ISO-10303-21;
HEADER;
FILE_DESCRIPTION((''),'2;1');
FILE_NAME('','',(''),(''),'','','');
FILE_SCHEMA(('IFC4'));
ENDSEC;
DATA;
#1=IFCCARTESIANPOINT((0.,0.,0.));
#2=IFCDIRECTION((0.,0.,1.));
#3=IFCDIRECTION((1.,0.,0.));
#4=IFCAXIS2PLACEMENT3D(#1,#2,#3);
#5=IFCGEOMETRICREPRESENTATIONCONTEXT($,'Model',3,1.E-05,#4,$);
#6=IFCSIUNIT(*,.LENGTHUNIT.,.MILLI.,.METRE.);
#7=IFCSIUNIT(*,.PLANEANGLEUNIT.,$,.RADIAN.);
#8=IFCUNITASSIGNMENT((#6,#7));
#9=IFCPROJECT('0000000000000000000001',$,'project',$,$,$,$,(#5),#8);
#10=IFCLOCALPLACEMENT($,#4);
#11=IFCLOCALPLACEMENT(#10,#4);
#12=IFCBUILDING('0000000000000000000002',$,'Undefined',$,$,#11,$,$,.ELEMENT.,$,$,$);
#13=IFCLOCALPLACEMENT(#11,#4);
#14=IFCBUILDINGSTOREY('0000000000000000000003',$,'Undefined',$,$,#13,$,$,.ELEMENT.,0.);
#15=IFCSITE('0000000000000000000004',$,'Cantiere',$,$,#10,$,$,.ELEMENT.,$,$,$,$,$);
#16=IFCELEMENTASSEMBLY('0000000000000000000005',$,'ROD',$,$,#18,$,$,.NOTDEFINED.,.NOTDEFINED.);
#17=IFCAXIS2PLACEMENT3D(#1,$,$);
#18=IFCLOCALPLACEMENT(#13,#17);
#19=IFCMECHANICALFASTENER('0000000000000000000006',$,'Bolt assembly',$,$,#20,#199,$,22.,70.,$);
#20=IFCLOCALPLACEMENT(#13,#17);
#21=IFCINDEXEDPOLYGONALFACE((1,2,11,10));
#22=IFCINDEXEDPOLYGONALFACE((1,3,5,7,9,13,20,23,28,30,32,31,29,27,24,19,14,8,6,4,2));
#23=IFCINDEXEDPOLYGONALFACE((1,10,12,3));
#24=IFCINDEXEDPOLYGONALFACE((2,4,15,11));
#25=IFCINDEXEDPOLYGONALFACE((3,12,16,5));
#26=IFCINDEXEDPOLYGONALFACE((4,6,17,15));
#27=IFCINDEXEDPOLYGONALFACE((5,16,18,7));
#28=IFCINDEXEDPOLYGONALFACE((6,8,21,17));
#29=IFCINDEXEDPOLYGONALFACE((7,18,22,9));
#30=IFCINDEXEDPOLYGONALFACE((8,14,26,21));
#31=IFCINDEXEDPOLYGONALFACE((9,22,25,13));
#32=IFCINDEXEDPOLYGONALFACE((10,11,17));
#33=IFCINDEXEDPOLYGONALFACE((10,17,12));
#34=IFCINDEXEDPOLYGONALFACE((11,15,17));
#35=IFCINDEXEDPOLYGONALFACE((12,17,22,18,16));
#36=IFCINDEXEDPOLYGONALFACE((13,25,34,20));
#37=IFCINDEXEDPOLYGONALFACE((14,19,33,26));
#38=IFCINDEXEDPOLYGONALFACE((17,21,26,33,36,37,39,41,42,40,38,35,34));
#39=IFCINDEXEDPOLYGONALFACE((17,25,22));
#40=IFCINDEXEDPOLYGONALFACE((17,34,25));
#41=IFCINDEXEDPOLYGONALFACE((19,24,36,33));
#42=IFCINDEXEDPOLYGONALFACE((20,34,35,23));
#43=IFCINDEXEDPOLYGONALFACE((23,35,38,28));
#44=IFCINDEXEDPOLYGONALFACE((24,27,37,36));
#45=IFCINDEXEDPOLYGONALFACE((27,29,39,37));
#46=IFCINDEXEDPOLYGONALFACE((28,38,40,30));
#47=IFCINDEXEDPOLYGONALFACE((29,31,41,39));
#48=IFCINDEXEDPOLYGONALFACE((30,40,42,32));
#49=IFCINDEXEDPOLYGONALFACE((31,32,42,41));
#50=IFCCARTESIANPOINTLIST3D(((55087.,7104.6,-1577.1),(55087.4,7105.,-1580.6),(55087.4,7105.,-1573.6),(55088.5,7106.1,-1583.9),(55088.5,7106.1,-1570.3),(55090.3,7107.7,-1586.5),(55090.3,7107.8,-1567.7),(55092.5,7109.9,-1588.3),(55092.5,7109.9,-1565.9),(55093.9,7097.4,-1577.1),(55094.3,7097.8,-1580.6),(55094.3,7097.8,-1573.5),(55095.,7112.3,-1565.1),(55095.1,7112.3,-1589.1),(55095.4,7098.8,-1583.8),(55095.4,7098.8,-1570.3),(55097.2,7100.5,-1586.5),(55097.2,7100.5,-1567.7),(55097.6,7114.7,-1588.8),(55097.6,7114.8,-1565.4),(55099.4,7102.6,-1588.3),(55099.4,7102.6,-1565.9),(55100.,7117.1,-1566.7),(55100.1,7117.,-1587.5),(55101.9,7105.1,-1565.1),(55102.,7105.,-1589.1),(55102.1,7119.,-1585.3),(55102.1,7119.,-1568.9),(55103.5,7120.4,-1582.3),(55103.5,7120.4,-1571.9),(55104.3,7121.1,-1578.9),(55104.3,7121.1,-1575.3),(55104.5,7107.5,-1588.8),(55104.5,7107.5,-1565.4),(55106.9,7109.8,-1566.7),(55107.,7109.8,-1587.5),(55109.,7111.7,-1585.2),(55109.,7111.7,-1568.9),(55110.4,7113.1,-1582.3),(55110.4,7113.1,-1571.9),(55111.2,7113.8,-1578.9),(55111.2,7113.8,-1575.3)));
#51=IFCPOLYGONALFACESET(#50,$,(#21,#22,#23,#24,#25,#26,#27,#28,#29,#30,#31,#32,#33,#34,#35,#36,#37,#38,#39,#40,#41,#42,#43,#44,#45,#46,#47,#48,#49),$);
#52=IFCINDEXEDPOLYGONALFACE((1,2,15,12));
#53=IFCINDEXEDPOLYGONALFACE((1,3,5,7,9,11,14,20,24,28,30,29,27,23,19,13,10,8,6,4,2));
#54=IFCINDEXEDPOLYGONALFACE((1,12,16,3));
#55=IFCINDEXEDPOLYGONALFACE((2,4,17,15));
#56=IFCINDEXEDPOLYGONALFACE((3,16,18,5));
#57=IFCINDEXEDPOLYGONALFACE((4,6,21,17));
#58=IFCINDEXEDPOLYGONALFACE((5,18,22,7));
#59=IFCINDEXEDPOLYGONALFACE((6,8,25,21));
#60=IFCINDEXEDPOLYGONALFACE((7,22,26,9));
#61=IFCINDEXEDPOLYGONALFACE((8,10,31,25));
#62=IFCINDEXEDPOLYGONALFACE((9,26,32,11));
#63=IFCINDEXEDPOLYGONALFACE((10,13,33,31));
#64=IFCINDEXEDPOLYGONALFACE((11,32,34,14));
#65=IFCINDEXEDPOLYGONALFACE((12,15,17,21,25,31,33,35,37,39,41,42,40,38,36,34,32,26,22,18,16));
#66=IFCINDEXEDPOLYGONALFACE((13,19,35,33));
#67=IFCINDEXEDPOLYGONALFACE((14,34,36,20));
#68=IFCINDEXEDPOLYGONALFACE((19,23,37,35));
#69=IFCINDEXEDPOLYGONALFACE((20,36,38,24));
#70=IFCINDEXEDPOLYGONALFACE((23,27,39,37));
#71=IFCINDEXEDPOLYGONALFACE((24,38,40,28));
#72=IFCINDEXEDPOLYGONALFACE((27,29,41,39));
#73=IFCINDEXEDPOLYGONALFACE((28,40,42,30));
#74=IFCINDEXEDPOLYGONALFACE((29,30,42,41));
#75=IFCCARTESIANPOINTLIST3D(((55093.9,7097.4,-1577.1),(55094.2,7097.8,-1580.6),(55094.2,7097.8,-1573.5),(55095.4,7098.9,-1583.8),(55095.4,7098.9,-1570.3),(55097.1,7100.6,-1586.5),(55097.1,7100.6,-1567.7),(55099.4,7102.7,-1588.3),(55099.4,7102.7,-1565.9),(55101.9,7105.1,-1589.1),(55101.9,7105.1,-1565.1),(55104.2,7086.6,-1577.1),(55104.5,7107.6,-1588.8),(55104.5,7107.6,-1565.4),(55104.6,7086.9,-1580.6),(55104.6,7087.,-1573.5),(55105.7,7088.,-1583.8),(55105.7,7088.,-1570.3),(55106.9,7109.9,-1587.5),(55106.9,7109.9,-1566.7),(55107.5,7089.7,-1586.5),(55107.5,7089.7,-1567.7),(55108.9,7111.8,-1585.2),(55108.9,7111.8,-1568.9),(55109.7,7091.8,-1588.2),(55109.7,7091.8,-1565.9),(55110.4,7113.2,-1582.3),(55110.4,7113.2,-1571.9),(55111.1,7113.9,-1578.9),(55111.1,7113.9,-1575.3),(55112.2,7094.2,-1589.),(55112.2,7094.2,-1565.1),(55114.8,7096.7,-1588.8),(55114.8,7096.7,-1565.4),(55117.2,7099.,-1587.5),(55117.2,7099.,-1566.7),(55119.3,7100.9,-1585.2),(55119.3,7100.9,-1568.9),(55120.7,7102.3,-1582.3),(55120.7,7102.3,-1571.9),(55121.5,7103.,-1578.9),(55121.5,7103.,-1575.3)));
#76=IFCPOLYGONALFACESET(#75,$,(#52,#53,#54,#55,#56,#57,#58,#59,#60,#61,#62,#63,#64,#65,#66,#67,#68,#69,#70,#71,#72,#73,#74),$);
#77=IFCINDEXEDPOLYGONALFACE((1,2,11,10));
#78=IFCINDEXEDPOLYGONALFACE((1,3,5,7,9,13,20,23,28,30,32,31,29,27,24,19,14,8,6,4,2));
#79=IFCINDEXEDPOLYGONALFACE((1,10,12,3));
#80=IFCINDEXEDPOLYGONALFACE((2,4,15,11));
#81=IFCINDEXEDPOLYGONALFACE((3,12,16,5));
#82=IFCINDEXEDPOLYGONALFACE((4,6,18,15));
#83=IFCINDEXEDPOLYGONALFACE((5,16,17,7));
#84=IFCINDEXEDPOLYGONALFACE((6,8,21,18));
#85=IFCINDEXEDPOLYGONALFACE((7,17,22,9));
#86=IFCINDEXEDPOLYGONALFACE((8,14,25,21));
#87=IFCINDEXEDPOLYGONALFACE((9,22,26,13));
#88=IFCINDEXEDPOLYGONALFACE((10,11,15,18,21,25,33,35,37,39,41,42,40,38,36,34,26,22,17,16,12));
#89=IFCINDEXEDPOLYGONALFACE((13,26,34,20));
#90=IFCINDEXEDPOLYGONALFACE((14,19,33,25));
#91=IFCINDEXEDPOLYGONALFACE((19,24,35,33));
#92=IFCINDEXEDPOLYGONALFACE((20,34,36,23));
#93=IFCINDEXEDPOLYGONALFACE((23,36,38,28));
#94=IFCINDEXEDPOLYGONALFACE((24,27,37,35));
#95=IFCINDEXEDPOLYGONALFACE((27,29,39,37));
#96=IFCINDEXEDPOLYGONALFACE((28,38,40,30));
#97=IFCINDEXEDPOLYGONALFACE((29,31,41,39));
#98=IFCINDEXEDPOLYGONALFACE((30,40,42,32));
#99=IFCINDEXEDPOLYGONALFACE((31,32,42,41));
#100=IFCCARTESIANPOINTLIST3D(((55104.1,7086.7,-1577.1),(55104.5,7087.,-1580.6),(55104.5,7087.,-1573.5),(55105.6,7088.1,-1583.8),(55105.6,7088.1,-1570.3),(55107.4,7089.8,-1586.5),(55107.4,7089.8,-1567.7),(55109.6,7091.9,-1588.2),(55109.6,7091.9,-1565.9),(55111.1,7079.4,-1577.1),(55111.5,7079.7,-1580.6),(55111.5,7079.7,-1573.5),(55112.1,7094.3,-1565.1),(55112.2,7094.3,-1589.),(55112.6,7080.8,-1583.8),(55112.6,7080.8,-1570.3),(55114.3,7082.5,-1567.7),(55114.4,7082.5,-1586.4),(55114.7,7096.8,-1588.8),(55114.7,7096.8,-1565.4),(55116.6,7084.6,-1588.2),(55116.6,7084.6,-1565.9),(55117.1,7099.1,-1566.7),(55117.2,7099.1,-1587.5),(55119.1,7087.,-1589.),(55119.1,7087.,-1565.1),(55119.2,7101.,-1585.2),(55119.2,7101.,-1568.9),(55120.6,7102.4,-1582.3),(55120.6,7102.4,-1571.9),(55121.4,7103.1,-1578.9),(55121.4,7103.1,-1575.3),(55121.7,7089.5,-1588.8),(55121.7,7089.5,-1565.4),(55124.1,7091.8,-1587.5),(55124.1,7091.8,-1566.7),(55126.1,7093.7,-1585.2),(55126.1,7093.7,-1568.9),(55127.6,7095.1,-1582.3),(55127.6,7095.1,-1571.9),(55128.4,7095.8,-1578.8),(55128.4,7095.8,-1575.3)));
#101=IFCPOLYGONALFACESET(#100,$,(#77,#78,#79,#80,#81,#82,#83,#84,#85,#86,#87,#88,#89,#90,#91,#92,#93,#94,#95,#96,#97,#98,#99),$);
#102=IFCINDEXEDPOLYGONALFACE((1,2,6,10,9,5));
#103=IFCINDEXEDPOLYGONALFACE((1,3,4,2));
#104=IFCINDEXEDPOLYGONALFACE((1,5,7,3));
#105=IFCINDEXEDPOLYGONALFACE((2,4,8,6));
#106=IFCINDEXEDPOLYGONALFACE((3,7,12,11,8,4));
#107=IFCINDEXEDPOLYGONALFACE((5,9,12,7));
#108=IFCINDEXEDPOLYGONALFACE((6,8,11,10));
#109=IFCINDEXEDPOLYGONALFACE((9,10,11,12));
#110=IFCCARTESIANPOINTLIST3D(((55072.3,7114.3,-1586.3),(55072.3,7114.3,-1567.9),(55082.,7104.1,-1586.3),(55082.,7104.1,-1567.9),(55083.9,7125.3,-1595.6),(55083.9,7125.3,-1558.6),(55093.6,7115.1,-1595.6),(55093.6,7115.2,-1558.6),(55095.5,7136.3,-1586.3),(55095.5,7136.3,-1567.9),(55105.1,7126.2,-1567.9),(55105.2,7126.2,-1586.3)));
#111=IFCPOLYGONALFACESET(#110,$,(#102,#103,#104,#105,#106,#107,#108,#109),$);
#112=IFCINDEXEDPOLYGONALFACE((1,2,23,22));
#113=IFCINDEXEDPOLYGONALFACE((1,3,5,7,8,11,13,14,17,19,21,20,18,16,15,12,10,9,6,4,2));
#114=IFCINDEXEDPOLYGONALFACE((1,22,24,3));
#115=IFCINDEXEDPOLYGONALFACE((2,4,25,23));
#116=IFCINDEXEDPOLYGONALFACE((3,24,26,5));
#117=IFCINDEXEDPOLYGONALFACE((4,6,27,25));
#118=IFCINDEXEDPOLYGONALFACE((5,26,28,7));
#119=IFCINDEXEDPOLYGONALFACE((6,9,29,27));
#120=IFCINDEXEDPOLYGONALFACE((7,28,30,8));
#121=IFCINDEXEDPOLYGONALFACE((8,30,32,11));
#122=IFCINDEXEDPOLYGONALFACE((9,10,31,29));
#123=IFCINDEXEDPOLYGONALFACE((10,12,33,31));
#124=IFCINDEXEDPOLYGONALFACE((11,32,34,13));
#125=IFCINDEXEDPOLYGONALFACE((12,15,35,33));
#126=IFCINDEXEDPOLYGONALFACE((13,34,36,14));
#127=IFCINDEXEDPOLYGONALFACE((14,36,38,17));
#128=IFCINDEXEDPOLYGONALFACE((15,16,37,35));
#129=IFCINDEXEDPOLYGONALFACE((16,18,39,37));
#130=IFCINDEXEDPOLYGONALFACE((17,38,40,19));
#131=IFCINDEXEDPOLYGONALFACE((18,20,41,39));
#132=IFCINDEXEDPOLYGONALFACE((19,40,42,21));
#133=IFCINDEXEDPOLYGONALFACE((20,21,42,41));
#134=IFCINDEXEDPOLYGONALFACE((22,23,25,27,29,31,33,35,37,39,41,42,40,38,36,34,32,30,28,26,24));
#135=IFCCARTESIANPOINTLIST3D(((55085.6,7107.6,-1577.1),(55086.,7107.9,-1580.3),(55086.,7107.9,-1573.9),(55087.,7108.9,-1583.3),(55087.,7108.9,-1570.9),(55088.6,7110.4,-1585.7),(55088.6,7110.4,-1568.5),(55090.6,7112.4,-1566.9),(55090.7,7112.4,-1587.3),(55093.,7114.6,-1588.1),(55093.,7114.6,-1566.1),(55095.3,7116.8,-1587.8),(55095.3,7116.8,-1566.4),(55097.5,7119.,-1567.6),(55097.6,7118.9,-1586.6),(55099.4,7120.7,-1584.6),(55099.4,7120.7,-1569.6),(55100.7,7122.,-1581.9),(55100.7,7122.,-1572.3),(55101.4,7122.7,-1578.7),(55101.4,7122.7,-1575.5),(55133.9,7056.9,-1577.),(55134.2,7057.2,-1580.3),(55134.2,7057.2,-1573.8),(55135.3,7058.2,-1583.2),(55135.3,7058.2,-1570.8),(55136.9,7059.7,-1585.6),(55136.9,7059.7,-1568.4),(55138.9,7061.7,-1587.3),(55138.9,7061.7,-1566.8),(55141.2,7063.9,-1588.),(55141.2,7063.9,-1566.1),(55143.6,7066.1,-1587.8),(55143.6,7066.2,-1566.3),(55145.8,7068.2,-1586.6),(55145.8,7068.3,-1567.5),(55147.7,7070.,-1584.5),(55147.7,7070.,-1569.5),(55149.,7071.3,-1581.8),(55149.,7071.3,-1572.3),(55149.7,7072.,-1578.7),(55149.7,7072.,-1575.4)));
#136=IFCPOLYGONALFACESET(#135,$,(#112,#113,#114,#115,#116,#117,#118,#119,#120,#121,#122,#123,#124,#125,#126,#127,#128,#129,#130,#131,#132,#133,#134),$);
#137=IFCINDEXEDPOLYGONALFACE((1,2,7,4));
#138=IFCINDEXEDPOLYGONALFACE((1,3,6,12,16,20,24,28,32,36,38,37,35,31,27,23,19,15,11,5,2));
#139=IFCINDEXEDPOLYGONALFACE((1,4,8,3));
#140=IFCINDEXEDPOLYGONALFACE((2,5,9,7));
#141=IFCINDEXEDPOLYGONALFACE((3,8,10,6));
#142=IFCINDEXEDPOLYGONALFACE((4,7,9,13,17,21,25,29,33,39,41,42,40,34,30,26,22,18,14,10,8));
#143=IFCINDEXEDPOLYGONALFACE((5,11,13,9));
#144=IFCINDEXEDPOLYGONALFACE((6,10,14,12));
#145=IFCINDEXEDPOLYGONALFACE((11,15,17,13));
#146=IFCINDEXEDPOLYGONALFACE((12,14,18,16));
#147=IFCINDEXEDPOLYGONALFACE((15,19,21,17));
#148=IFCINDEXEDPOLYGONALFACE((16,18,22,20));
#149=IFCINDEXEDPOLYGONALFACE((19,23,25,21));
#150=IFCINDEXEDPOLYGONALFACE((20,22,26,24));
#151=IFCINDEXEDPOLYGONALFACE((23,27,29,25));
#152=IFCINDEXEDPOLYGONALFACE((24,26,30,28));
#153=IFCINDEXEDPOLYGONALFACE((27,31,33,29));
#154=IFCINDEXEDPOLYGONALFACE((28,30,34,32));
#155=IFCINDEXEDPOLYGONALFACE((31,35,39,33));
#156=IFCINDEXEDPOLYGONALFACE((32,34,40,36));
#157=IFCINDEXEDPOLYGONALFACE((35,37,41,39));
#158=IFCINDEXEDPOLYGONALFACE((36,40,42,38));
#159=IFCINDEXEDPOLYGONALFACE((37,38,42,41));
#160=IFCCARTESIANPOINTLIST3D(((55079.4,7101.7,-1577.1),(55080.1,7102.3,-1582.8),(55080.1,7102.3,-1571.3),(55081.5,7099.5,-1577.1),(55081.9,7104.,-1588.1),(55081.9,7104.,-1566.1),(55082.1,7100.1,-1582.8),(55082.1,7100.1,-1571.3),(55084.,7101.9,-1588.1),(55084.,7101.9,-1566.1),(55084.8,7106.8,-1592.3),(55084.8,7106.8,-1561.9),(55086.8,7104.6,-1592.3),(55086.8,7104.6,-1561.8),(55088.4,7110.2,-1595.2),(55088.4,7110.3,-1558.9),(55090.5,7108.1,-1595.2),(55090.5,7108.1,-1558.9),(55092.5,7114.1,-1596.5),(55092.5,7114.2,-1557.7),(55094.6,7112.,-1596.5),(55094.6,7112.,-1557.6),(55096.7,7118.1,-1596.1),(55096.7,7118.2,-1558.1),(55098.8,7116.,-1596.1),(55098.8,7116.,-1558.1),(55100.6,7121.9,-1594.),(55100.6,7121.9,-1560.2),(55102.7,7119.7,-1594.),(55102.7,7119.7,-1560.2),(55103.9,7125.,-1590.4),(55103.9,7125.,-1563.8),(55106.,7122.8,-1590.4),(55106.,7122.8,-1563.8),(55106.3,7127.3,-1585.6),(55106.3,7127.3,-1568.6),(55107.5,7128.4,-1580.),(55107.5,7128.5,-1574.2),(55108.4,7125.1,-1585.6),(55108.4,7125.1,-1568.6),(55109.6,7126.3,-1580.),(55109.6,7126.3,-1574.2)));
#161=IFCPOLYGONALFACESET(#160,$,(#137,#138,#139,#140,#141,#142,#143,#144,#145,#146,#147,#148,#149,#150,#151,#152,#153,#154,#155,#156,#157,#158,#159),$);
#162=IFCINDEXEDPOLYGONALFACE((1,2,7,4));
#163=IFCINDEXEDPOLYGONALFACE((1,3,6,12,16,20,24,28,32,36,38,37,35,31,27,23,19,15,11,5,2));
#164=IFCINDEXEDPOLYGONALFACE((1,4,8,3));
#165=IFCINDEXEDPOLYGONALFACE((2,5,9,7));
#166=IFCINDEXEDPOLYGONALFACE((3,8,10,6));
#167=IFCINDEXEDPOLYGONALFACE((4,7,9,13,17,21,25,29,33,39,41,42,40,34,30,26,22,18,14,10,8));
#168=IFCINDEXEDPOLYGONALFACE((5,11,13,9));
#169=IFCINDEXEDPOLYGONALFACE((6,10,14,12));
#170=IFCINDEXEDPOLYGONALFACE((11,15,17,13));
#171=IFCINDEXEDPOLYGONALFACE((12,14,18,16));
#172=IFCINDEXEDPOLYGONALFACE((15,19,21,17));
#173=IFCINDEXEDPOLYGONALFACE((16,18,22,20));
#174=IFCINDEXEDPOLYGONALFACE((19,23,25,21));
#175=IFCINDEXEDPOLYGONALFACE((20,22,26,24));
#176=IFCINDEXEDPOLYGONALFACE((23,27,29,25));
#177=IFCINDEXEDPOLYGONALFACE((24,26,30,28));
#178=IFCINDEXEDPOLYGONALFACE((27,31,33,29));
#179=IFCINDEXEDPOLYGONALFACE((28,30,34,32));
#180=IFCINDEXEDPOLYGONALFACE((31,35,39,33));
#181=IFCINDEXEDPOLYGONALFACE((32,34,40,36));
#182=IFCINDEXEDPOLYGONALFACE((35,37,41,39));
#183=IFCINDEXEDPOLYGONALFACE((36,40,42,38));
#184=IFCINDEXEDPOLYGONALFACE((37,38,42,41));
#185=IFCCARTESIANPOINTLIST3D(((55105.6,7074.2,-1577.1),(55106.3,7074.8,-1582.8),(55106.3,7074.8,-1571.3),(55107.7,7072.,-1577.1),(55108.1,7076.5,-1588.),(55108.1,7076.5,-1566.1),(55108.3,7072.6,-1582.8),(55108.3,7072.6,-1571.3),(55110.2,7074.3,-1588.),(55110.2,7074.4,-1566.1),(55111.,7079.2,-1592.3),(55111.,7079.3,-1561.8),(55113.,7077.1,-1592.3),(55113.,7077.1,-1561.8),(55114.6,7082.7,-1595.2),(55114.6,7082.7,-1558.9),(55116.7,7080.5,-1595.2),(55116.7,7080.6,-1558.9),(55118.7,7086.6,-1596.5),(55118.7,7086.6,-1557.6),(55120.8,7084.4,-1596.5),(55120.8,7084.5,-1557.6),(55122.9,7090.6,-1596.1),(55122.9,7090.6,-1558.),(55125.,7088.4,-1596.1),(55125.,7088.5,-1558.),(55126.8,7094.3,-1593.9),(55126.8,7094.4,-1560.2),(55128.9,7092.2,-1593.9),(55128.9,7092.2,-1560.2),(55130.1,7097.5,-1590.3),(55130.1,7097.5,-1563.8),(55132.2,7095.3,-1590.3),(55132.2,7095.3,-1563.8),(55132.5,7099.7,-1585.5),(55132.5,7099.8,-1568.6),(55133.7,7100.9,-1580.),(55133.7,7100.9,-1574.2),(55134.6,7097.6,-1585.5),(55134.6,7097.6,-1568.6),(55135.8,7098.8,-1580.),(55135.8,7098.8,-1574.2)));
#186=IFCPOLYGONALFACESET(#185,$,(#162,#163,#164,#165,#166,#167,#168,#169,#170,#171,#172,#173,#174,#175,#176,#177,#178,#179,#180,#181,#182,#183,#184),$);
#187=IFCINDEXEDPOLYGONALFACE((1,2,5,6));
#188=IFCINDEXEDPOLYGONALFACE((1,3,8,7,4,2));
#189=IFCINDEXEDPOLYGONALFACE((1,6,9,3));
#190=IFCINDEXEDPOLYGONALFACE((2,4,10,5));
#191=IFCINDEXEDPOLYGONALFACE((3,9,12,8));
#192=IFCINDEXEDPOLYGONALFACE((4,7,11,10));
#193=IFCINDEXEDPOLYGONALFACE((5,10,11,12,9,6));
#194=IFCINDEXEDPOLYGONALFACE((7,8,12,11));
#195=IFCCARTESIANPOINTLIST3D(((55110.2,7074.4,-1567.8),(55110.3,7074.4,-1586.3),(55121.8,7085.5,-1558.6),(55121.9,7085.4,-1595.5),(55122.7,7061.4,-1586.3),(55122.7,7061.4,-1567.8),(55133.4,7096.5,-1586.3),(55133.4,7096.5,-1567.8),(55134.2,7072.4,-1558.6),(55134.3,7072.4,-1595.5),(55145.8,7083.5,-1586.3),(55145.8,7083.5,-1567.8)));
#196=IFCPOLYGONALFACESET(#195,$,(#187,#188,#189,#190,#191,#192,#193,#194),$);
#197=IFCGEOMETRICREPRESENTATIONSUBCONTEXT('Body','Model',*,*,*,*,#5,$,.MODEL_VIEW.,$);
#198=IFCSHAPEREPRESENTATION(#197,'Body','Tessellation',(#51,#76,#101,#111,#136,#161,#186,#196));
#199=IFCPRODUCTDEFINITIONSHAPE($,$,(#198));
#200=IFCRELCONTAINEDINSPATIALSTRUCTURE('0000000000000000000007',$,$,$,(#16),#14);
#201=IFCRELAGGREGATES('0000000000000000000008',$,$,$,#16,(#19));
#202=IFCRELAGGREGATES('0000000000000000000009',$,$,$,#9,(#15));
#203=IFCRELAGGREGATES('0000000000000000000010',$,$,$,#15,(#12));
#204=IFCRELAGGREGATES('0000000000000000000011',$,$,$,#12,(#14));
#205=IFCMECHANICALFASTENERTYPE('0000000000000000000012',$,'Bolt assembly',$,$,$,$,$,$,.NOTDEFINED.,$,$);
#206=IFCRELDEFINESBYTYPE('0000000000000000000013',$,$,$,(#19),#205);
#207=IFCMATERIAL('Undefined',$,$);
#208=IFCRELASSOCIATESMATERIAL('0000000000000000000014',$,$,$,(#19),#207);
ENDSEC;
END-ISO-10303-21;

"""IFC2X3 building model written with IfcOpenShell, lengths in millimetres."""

from ifc_helpers import new_model, si_unit, frame, origin_with_axes, origin_2d_with_axis, place, context, subcontext, project, spatial, polyline, circle, outline, extrude, source, transform, mapped, material, type_object, element, aggregate, save


model = new_model("IFC2X3")

# Units and contexts
model_context = context("Model", 3, precision=1e-05, world=origin_with_axes())
body_context = subcontext(model_context, "Body", "Model", "MODEL_VIEW")
ifc_project = project(units=[si_unit("LENGTHUNIT", "METRE", prefix="MILLI"), si_unit("PLANEANGLEUNIT", "RADIAN")], contexts=[model_context])

# Site, building, storey
site_placement = place(None, origin_with_axes())
site = spatial("IfcSite", under=ifc_project, at=site_placement, Name="Cantiere", CompositionType="ELEMENT")
building_placement = place(site_placement, origin_with_axes())
building = spatial("IfcBuilding", under=site, at=building_placement, Name="Undefined", CompositionType="ELEMENT")
storey_placement = place(building_placement, origin_with_axes())
storey = spatial("IfcBuildingStorey", under=building, at=storey_placement, Name="Undefined", CompositionType="ELEMENT", Elevation=0.0)

# Element assembly
assembly_1_placement = place(storey_placement, origin_with_axes())
assembly_1 = element("IfcElementAssembly", 1, at=assembly_1_placement, inside=storey, Name="ROD", AssemblyPlace="NOTDEFINED", PredefinedType="NOTDEFINED")

# Mechanical fastener
ifc_material_1 = material(Name="Undefined")
mechanical_fastener_type = type_object("IfcMechanicalFastenerType", Name="Bolt assembly")
shared_shape_1 = source(origin_with_axes(), body_context, "Body", "SweptSolid", [
    extrude(circle(Radius=12.0, at=origin_2d_with_axis()), frame((0.0, 0.1, 0.0), z_axis=(0.0, 1.0, 0.0), x_axis=(1.0, 0.0, 0.0)), (0.0, 0.0, 1.0), 10.0),
    extrude(circle(Radius=12.0, at=origin_2d_with_axis()), frame((0.0, 10.0, 0.0), z_axis=(0.0, 1.0, 0.0), x_axis=(1.0, 0.0, 0.0)), (0.0, 0.0, 1.0), 15.0),
    extrude(circle(Radius=12.0, at=origin_2d_with_axis()), frame((0.0, 24.9, 0.0), z_axis=(0.0, 1.0, 0.0), x_axis=(1.0, 0.0, 0.0)), (0.0, 0.0, 1.0), 10.1),
    extrude(outline(polyline([(16.0, -9.2), (16.0, 9.2), (0.0, 18.5), (-16.0, 9.2), (-16.0, -9.2), (0.0, -18.5), (16.0, -9.2)])), frame((0.0, -17.0, 0.0), z_axis=(0.0, 1.0, 0.0), x_axis=(1.0, 0.0, 0.0)), (0.0, 0.0, 1.0), 14.0),
    extrude(circle(Radius=11.0, at=origin_2d_with_axis()), frame((0.0, -3.0, 0.0), z_axis=(0.0, 1.0, 0.0), x_axis=(1.0, 0.0, 0.0)), (0.0, 0.0, 1.0), 70.0),
    extrude(circle(Radius=19.5, at=origin_2d_with_axis()), frame((0.0, -3.0, 0.0), z_axis=(0.0, 1.0, 0.0), x_axis=(1.0, 0.0, 0.0)), (0.0, 0.0, 1.0), 3.0),
    extrude(circle(Radius=19.5, at=origin_2d_with_axis()), frame((0.0, 35.0, 0.0), z_axis=(0.0, 1.0, 0.0), x_axis=(1.0, 0.0, 0.0)), (0.0, 0.0, 1.0), 3.0),
    extrude(outline(polyline([(16.0, -9.2), (16.0, 9.2), (0.0, 18.5), (-16.0, 9.2), (-16.0, -9.2), (0.0, -18.5), (16.0, -9.2)])), frame((0.0, 38.0, 0.0), z_axis=(0.0, 1.0, 0.0), x_axis=(1.0, 0.0, 0.0)), (0.0, 0.0, 1.0), 18.0),
])
mechanical_fastener_1_placement = place(assembly_1_placement, frame((55095.6, 7113.0, -1577.1), z_axis=(-0.000672, 0.000704, 1.0), x_axis=(-0.724208, -0.689582, -0.000002)))
mechanical_fastener_1 = element("IfcMechanicalFastener", 2, at=mechanical_fastener_1_placement, type_object=mechanical_fastener_type, material=ifc_material_1, Name="Bolt assembly", NominalDiameter=22.0, NominalLength=70.0, context=body_context, shape_type="MappedRepresentation", body=[
    mapped(shared_shape_1, transform((0.0, 0.0, 0.0))),
])
aggregate(assembly_1, [mechanical_fastener_1])

save(model, "model.ifc")
